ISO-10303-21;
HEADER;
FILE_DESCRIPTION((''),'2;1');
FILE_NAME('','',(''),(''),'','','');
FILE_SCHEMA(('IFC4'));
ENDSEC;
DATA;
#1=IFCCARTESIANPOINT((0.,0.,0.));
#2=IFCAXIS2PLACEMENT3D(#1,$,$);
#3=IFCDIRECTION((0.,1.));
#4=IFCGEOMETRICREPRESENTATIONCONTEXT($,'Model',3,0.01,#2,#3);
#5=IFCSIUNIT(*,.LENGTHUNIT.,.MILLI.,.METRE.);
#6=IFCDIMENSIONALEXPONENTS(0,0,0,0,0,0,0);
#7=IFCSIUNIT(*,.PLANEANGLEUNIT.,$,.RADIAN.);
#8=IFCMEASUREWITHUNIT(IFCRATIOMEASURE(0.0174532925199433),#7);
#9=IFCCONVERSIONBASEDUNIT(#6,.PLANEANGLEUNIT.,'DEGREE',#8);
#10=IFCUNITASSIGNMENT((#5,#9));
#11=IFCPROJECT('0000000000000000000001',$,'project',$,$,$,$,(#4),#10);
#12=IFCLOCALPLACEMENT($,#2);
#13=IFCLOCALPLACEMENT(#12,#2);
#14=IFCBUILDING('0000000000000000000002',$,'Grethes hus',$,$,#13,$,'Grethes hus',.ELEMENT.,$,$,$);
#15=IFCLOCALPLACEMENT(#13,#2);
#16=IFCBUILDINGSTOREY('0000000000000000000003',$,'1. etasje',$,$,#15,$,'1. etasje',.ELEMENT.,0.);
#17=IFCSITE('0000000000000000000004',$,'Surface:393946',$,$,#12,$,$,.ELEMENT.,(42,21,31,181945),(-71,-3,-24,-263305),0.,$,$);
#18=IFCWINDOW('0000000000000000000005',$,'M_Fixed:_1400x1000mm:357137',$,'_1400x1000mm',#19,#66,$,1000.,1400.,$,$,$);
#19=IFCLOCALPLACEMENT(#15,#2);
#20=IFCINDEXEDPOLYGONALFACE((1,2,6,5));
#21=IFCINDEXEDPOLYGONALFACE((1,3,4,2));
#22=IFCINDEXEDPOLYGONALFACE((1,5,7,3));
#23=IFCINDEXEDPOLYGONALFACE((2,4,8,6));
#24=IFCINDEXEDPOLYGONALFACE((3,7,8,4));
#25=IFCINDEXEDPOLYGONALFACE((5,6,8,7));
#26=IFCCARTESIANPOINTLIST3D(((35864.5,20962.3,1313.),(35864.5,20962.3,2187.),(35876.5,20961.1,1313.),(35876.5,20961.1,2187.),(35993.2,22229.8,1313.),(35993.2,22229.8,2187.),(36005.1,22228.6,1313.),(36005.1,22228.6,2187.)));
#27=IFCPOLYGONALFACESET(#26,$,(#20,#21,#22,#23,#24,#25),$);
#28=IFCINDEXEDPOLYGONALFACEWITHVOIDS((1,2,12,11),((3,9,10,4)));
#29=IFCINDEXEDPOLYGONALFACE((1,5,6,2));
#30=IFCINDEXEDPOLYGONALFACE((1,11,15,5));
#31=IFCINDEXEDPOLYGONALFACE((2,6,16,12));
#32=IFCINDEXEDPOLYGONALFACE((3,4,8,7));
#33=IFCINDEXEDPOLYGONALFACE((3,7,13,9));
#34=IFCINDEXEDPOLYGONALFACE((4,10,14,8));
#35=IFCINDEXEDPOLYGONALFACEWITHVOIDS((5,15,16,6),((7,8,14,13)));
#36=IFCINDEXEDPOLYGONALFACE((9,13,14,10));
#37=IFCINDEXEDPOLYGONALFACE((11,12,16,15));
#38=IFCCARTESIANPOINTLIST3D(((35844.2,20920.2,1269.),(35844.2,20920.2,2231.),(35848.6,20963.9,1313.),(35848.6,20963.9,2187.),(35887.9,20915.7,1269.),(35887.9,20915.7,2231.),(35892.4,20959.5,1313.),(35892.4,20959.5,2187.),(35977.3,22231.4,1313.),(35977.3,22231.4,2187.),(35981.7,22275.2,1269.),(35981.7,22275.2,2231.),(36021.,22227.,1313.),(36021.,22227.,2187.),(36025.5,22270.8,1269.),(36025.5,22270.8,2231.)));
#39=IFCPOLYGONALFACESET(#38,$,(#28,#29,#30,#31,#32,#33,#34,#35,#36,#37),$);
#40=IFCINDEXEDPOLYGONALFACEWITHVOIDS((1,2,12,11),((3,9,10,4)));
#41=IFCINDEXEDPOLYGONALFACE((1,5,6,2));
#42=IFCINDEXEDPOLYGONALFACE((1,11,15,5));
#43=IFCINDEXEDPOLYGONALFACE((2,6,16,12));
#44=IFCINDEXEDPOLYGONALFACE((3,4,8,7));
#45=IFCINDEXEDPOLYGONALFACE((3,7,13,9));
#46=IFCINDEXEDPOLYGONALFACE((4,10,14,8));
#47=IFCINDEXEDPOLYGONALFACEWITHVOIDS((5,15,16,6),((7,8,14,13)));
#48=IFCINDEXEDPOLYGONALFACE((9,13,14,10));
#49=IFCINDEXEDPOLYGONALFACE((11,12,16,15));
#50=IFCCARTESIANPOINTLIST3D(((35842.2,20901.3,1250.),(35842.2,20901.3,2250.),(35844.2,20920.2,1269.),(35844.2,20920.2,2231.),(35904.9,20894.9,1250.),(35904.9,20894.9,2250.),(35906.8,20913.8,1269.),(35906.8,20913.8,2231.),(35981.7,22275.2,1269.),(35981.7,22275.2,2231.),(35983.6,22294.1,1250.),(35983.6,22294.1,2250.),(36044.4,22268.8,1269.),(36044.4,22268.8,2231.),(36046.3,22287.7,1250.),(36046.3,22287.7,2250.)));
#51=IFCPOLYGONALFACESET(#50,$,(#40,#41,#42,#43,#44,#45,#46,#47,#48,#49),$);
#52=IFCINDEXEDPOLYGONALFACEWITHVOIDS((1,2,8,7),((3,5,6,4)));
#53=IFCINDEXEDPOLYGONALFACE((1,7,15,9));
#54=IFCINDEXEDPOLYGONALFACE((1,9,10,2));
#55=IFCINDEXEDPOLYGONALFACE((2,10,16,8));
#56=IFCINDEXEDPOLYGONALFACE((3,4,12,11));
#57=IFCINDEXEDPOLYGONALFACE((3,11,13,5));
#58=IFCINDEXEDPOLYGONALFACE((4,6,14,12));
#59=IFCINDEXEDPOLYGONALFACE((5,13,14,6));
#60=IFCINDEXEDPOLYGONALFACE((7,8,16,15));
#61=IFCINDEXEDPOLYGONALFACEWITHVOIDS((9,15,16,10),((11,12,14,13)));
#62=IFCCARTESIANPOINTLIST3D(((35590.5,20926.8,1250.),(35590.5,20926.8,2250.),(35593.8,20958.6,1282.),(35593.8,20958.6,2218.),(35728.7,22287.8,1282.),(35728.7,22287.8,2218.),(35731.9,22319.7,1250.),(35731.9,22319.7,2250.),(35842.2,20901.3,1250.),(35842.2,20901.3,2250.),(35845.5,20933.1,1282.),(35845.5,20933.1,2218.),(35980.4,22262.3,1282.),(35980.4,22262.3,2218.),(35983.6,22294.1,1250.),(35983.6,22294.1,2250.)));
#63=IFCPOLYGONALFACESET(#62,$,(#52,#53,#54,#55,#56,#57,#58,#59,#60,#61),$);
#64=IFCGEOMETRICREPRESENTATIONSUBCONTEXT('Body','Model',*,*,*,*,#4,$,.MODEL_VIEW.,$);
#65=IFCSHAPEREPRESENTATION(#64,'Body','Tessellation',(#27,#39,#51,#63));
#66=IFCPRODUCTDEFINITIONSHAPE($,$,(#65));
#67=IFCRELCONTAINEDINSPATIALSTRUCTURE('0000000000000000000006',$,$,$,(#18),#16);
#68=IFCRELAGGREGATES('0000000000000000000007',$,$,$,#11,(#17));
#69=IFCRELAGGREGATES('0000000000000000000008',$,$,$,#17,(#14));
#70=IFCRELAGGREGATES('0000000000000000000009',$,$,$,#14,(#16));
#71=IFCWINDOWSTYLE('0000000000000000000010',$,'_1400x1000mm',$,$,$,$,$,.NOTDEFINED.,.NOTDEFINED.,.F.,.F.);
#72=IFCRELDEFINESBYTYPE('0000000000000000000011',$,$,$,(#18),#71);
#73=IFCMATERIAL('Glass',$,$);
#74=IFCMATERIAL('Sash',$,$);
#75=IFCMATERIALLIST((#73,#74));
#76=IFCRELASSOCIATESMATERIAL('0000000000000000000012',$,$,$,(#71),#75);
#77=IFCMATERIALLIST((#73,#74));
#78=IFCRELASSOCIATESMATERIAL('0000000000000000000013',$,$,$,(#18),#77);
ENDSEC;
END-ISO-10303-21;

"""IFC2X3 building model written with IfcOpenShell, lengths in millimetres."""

from ifc_helpers import new_model, entity, si_unit, converted_unit, direction, frame, frame_2d, origin, place, context, subcontext, project, spatial, polyline, rectangle, outline, extrude, source, transform, mapped, material, material_list, type_object, type_shapes, element, save


model = new_model("IFC2X3")

# Units and contexts
model_context = context("Model", 3, precision=0.01, world=origin(), true_north=direction((0.0, 1.0)))
body_context = subcontext(model_context, "Body", "Model", "MODEL_VIEW")
ifc_project = project(units=[si_unit("LENGTHUNIT", "METRE", prefix="MILLI"), converted_unit("PLANEANGLEUNIT", "DEGREE", entity("IfcRatioMeasure", 0.0174532925199433), si_unit("PLANEANGLEUNIT", "RADIAN"), dimensions=[0, 0, 0, 0, 0, 0, 0])], contexts=[model_context])

# Site, building, storey
site_placement = place(None, origin())
site = spatial("IfcSite", under=ifc_project, at=site_placement, Name="Surface:393946", CompositionType="ELEMENT", RefLatitude=(42, 21, 31, 181945), RefLongitude=(-71, -3, -24, -263305), RefElevation=0.0)
building_placement = place(site_placement, origin())
building = spatial("IfcBuilding", under=site, at=building_placement, Name="Grethes hus", LongName="Grethes hus", CompositionType="ELEMENT")
storey_placement = place(building_placement, origin())
storey = spatial("IfcBuildingStorey", under=building, at=storey_placement, Name="1. etasje", LongName="1. etasje", CompositionType="ELEMENT", Elevation=0.0)

# Window
ifc_material_1 = material(Name="Glass")
ifc_material_2 = material(Name="Sash")
placement_1 = place(storey_placement, frame((36234.1, 25702.2, 0.0), z_axis=(0.0, 0.0, 1.0), x_axis=(-0.100996, -0.994887, 0.0)))
ifc_material_list_1 = material_list([ifc_material_1, ifc_material_2])
ifc_material_list_2 = material_list([ifc_material_1, ifc_material_2])
window_style_1 = type_object("IfcWindowStyle", Name="_1400x1000mm", ConstructionType="NOTDEFINED", OperationType="NOTDEFINED", ParameterTakesPrecedence=False, Sizeable=False, material=ifc_material_list_2)
shared_shape_1 = source(origin(), body_context, "Body", "SweptSolid", [
    extrude(rectangle(XDim=12.0, YDim=1274.0, at=frame_2d((0.0, 0.0), x_axis=(1.0, 0.0))), frame((700.0, 275.0, 63.0), z_axis=(0.0, 0.0, 1.0), x_axis=(0.0, -1.0, 0.0)), (0.0, 0.0, 1.0), 874.0),
    extrude(outline(polyline([(-681.0, -481.0), (681.0, -481.0), (681.0, 481.0), (-681.0, 481.0), (-681.0, -481.0)]), holes=[polyline([(-637.0, -437.0), (-637.0, 437.0), (637.0, 437.0), (637.0, -437.0), (-637.0, -437.0)])]), frame((700.0, 253.0, 500.0), z_axis=(0.0, 1.0, 0.0), x_axis=(1.0, 0.0, 0.0)), (0.0, 0.0, 1.0), 44.0),
    extrude(outline(polyline([(-700.0, -500.0), (700.0, -500.0), (700.0, 500.0), (-700.0, 500.0), (-700.0, -500.0)]), holes=[polyline([(-681.0, -481.0), (-681.0, 481.0), (681.0, 481.0), (681.0, -481.0), (-681.0, -481.0)])]), frame((700.0, 253.0, 500.0), z_axis=(0.0, 1.0, 0.0), x_axis=(1.0, 0.0, 0.0)), (0.0, 0.0, 1.0), 63.0),
    extrude(outline(polyline([(-700.0, -500.0), (700.0, -500.0), (700.0, 500.0), (-700.0, 500.0), (-700.0, -500.0)]), holes=[polyline([(-668.0, -468.0), (-668.0, 468.0), (668.0, 468.0), (668.0, -468.0), (-668.0, -468.0)])]), frame((700.0, 0.0, 500.0), z_axis=(0.0, 1.0, 0.0), x_axis=(1.0, 0.0, 0.0)), (0.0, 0.0, 1.0), 253.0),
])
type_shapes(window_style_1, [shared_shape_1])
placement_2 = place(placement_1, frame((3416.0, -158.0, 1250.0)))
window_1_placement = place(placement_2, origin())
element("IfcWindow", 1, at=window_1_placement, inside=storey, type_object=window_style_1, material=ifc_material_list_1, Name="M_Fixed:_1400x1000mm:357137", ObjectType="_1400x1000mm", OverallHeight=1000.0, OverallWidth=1400.0, context=body_context, shape_type="MappedRepresentation", body=[
    mapped(shared_shape_1, transform((0.0, 0.0, 0.0), scale=1.0)),
])

save(model, "model.ifc")
